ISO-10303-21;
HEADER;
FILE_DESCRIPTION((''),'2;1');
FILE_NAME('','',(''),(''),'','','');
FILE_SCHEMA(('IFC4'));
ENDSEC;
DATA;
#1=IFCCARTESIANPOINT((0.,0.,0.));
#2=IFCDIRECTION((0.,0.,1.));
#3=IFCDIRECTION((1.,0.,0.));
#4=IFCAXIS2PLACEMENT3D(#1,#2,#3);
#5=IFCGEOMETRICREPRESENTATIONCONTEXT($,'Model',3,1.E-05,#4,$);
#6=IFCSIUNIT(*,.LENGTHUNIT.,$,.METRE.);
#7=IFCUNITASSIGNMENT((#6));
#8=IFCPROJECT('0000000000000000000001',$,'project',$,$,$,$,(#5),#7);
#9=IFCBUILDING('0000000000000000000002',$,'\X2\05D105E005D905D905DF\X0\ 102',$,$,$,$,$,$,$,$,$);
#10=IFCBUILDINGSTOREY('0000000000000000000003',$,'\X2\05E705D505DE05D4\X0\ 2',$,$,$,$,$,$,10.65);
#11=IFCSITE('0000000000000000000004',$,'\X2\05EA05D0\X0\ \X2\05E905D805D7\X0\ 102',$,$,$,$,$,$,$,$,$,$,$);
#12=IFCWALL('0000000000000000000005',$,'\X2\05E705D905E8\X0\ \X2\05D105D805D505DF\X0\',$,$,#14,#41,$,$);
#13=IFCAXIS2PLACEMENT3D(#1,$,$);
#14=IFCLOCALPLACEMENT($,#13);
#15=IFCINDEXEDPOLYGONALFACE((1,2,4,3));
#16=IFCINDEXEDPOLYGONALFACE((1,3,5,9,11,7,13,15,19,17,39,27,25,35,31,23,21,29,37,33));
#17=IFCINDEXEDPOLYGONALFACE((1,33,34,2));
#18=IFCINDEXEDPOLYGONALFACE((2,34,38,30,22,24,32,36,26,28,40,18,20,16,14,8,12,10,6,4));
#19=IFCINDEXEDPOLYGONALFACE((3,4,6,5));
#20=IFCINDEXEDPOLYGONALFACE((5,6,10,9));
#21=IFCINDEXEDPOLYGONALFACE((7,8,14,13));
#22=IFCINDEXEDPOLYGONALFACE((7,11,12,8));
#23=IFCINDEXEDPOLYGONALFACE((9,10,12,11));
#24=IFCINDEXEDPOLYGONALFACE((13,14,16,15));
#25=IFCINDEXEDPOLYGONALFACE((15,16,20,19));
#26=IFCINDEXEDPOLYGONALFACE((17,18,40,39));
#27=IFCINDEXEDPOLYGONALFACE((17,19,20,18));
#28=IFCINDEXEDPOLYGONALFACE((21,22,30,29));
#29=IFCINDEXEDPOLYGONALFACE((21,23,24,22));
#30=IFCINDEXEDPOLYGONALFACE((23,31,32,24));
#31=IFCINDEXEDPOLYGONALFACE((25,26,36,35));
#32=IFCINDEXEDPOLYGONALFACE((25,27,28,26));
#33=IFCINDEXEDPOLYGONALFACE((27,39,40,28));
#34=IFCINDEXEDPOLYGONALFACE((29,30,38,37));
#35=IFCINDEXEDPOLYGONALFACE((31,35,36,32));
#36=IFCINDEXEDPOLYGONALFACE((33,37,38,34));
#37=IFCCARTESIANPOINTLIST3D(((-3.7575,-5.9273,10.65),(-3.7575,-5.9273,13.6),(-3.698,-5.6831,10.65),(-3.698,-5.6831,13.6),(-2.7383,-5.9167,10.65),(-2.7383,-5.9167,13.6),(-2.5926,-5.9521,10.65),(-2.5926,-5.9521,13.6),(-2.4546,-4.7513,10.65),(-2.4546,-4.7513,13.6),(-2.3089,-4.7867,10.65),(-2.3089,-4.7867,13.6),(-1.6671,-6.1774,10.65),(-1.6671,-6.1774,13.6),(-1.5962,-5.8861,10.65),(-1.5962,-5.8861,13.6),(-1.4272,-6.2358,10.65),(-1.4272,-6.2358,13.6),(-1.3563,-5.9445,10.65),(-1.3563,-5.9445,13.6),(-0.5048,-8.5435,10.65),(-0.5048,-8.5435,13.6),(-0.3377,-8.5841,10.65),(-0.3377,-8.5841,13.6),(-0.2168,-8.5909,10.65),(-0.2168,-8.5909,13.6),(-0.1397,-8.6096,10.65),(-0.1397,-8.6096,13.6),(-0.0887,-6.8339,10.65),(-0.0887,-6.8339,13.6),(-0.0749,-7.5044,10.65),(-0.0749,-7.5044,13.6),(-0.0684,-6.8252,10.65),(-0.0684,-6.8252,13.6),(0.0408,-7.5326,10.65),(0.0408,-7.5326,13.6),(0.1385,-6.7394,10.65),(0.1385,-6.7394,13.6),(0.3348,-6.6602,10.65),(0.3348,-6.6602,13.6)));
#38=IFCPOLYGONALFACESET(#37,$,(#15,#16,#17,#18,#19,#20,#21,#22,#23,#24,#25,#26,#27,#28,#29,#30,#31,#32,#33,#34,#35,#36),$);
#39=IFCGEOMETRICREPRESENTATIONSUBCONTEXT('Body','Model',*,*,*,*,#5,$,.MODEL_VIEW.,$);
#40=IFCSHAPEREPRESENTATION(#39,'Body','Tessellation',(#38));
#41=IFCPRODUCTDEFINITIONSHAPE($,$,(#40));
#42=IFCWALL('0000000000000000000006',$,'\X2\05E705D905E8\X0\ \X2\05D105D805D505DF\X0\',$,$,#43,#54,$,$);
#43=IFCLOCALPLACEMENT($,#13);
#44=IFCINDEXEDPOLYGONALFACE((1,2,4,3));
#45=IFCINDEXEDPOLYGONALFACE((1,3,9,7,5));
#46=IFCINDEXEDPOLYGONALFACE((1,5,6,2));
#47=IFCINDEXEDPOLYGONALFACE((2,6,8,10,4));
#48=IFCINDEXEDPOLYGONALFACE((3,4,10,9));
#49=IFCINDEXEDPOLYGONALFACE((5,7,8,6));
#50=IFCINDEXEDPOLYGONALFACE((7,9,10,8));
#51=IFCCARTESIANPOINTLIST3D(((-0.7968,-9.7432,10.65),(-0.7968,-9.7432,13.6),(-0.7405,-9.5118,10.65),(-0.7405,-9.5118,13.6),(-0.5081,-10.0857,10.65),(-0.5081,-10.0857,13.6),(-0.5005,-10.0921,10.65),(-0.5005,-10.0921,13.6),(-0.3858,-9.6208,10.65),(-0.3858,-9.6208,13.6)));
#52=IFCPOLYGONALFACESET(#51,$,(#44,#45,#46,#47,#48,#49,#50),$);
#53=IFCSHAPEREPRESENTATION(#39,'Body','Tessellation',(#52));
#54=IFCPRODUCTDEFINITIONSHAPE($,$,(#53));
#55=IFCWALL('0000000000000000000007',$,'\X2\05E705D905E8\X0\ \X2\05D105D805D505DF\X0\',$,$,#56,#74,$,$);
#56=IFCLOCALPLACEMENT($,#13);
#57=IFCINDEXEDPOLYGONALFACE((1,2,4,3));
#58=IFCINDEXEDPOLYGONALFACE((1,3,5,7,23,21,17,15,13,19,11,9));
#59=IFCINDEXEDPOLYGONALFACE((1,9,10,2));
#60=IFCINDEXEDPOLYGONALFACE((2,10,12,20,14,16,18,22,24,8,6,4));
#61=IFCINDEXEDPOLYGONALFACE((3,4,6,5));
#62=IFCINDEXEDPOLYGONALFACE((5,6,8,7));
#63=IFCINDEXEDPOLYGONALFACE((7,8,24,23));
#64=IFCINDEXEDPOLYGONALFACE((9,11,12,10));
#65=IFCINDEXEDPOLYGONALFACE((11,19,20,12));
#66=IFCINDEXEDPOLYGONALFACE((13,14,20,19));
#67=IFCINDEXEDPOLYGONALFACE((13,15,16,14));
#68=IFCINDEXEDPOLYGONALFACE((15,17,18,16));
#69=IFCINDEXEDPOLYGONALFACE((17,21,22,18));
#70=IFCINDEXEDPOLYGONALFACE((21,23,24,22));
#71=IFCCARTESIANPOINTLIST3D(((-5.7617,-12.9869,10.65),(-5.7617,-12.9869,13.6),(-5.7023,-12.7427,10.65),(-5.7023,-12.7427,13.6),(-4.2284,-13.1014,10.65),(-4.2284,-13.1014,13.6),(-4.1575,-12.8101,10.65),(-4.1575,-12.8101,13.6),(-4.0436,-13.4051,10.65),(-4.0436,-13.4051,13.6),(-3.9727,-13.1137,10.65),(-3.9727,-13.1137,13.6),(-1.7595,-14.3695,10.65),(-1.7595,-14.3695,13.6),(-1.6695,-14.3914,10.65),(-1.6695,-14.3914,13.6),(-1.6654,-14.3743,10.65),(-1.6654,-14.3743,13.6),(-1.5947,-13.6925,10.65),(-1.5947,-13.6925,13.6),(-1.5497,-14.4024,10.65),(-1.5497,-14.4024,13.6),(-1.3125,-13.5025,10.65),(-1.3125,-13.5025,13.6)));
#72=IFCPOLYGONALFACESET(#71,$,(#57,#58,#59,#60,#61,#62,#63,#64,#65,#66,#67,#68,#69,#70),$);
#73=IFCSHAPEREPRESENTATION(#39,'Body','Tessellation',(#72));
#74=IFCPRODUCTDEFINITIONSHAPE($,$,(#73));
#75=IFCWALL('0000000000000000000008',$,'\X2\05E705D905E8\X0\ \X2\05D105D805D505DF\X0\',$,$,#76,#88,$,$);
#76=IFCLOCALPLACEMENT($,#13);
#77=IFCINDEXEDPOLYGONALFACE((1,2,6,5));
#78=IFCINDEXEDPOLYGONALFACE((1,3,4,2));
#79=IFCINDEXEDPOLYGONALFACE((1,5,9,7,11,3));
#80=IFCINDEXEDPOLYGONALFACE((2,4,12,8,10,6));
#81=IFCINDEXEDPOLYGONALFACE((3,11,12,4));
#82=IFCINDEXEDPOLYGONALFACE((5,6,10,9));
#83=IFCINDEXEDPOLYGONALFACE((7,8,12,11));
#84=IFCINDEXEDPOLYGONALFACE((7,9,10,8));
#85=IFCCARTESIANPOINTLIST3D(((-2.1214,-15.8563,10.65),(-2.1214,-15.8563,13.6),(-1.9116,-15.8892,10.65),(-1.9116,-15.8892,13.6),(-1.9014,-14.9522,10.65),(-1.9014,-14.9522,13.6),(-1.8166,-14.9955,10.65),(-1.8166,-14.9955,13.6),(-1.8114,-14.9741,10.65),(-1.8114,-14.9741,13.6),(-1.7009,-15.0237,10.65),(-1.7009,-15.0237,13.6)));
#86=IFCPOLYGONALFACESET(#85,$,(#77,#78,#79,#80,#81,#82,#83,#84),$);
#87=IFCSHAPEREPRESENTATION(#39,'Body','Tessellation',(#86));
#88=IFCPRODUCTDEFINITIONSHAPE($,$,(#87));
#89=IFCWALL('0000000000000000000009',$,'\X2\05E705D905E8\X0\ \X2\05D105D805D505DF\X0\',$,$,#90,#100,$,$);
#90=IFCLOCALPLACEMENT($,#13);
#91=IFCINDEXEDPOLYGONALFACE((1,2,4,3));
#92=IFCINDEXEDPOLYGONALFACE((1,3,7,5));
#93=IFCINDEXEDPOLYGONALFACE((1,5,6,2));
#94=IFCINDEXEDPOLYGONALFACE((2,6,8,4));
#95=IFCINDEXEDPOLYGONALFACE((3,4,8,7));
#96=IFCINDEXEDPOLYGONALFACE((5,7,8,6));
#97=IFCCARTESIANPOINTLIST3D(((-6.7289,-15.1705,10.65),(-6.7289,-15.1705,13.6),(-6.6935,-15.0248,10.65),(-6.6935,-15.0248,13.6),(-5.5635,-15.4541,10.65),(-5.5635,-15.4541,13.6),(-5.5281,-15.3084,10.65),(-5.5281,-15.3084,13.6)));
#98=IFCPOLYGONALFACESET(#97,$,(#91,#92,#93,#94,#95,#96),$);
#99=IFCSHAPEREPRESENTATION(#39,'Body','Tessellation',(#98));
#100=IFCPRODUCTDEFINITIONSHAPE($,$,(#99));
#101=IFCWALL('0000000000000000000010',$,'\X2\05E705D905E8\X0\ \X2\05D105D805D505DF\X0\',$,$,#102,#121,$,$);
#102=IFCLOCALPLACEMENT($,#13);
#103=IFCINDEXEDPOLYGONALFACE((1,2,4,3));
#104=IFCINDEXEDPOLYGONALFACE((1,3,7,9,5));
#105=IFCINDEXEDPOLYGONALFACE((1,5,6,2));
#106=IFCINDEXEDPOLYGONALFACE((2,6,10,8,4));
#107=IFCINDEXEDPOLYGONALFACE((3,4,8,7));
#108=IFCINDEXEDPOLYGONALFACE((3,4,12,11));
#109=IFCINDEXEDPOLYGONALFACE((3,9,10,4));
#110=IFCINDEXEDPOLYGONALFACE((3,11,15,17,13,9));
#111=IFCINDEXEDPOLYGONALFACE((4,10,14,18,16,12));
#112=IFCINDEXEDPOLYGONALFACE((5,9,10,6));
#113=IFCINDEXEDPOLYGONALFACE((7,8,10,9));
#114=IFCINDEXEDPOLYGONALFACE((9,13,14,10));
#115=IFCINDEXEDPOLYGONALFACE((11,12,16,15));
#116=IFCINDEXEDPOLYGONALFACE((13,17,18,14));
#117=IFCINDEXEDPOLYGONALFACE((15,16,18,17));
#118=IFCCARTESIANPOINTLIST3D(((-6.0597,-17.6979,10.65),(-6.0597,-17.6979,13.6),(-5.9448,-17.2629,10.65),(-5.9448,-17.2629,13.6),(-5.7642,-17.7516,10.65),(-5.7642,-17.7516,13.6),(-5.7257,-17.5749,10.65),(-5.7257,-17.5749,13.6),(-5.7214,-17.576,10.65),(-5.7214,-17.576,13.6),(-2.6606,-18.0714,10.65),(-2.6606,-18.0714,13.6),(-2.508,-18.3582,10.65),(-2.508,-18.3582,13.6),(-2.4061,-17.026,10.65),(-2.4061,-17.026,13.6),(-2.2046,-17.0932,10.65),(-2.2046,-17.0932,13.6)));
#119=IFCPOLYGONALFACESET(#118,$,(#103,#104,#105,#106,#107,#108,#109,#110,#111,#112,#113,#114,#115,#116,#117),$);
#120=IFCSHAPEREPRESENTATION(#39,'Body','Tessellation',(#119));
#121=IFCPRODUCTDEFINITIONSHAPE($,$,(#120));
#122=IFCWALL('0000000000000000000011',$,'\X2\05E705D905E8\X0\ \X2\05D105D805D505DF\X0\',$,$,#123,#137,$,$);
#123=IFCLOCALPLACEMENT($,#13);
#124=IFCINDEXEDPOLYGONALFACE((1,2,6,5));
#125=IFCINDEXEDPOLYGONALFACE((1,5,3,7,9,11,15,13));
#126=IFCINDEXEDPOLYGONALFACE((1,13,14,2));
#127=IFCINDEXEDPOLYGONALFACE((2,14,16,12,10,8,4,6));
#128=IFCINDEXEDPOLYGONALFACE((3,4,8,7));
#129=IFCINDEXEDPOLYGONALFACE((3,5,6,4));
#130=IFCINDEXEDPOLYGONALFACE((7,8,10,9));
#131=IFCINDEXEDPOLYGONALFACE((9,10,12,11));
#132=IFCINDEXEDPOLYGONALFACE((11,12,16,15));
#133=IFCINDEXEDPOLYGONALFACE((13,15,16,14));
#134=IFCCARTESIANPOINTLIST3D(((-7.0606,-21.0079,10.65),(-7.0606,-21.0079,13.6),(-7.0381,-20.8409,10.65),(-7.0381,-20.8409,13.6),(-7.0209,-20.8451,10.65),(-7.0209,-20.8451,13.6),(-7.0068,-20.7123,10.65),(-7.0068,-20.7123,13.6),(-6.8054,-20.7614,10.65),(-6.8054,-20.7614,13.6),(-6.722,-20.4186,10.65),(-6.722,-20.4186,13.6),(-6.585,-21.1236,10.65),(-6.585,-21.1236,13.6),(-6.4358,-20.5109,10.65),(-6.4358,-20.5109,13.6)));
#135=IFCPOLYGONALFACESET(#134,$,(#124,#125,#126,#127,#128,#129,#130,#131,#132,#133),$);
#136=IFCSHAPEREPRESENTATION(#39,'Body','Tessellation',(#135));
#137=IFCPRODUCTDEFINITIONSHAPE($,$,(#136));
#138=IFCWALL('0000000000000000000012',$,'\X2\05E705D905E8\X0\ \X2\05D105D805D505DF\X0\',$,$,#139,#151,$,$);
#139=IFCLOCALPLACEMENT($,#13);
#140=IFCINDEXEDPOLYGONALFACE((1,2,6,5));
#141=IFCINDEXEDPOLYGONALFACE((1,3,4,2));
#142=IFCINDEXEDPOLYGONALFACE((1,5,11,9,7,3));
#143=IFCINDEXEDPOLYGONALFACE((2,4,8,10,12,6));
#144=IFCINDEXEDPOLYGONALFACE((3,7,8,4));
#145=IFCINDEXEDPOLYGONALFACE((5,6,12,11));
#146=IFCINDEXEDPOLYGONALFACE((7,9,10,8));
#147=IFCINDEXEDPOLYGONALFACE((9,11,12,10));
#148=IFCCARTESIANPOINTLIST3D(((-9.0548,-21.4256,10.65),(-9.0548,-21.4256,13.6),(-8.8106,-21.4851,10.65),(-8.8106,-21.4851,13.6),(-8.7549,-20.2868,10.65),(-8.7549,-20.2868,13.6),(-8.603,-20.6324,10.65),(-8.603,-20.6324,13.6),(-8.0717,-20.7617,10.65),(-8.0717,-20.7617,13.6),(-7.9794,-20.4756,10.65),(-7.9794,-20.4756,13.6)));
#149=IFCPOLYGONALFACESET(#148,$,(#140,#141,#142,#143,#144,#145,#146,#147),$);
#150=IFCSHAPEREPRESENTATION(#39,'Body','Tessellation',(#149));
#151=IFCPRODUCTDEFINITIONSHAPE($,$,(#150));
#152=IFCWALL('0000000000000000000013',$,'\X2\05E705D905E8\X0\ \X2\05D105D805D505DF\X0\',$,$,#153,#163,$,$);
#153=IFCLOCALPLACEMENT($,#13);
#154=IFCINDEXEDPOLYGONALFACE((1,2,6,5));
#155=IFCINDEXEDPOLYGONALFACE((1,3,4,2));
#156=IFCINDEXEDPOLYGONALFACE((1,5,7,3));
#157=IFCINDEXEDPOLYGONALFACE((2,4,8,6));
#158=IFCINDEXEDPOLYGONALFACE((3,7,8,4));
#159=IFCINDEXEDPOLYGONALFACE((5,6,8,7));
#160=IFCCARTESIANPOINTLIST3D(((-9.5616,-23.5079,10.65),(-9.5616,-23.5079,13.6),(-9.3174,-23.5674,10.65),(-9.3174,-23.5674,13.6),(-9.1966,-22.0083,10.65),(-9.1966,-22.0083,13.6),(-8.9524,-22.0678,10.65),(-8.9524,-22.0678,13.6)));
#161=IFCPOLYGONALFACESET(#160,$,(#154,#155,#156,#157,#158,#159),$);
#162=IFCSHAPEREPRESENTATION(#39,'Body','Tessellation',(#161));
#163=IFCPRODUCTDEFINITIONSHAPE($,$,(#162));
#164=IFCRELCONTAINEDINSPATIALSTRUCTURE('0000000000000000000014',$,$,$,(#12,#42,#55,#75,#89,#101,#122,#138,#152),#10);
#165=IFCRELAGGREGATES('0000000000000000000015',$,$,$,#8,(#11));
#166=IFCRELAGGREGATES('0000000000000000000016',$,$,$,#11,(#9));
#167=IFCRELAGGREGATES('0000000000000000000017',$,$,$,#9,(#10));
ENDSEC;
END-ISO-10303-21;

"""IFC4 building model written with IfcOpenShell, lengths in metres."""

from ifc_helpers import new_model, si_unit, frame, origin_with_axes, context, subcontext, project, spatial, polyline, outline, extrude, element, save


model = new_model("IFC4")

# Units and contexts
model_context = context("Model", 3, precision=1e-05, world=origin_with_axes())
body_context = subcontext(model_context, "Body", "Model", "MODEL_VIEW")
ifc_project = project(units=[si_unit("LENGTHUNIT", "METRE")], contexts=[model_context])

# Site, building, storey
site = spatial("IfcSite", under=ifc_project, Name="תא שטח 102")
building = spatial("IfcBuilding", under=site, Name="בניין 102")
storey = spatial("IfcBuildingStorey", under=building, Name="קומה 2", Elevation=10.65)

# Walls
element("IfcWall", 1, inside=storey, Name="קיר בטון", context=body_context, shape_type="SweptSolid", body=[
    extrude(outline(polyline([(-2.4546, -4.7513), (-2.7383, -5.9167), (-3.698, -5.6831), (-3.7575, -5.9273), (-0.0684, -6.8252), (0.1385, -6.7394), (-0.0887, -6.8339), (-0.5048, -8.5435), (-0.3377, -8.5841), (-0.0749, -7.5044), (0.0408, -7.5326), (-0.2168, -8.5909), (-0.1397, -8.6096), (0.3348, -6.6602), (-1.4272, -6.2358), (-1.3563, -5.9445), (-1.5962, -5.8861), (-1.6671, -6.1774), (-2.5926, -5.9521), (-2.3089, -4.7867), (-2.4546, -4.7513)])), frame((0.0, 0.0, 10.65)), (0.0, 0.0, 1.0), 2.95),
])
element("IfcWall", 2, inside=storey, Name="קיר בטון", context=body_context, shape_type="SweptSolid", body=[
    extrude(outline(polyline([(-0.3858, -9.6208), (-0.7405, -9.5118), (-0.7968, -9.7432), (-0.5081, -10.0857), (-0.5005, -10.0921), (-0.3858, -9.6208)])), frame((0.0, 0.0, 10.65)), (0.0, 0.0, 1.0), 2.95),
])
element("IfcWall", 3, inside=storey, Name="קיר בטון", context=body_context, shape_type="SweptSolid", body=[
    extrude(outline(polyline([(-5.7617, -12.9869), (-4.0436, -13.4051), (-3.9727, -13.1137), (-1.5947, -13.6925), (-1.7595, -14.3695), (-1.6695, -14.3914), (-1.6654, -14.3743), (-1.5497, -14.4024), (-1.3125, -13.5025), (-4.1575, -12.8101), (-4.2284, -13.1014), (-5.7023, -12.7427), (-5.7617, -12.9869)])), frame((0.0, 0.0, 10.65)), (0.0, 0.0, 1.0), 2.95),
])
element("IfcWall", 4, inside=storey, Name="קיר בטון", context=body_context, shape_type="SweptSolid", body=[
    extrude(outline(polyline([(-2.1214, -15.8563), (-1.9116, -15.8892), (-1.7009, -15.0237), (-1.8166, -14.9955), (-1.8114, -14.9741), (-1.9014, -14.9522), (-2.1214, -15.8563)])), frame((0.0, 0.0, 10.65)), (0.0, 0.0, 1.0), 2.95),
])
element("IfcWall", 5, inside=storey, Name="קיר בטון", context=body_context, shape_type="SweptSolid", body=[
    extrude(outline(polyline([(-6.7289, -15.1705), (-5.5635, -15.4541), (-5.5281, -15.3084), (-6.6935, -15.0248), (-6.7289, -15.1705)])), frame((0.0, 0.0, 10.65)), (0.0, 0.0, 1.0), 2.95),
])
element("IfcWall", 6, inside=storey, Name="קיר בטון", context=body_context, shape_type="SweptSolid", body=[
    extrude(outline(polyline([(-5.9448, -17.2629), (-6.0597, -17.6979), (-5.7642, -17.7516), (-5.7214, -17.576), (-2.508, -18.3582), (-2.2046, -17.0932), (-2.4061, -17.026), (-2.6606, -18.0714), (-5.9448, -17.2629)]), holes=[polyline([(-5.7257, -17.5749), (-5.7214, -17.576), (-5.9448, -17.2629), (-5.7257, -17.5749)])]), frame((0.0, 0.0, 10.65)), (0.0, 0.0, 1.0), 2.95),
])
element("IfcWall", 7, inside=storey, Name="קיר בטון", context=body_context, shape_type="SweptSolid", body=[
    extrude(outline(polyline([(-7.0209, -20.8451), (-7.0606, -21.0079), (-6.585, -21.1236), (-6.4358, -20.5109), (-6.722, -20.4186), (-6.8054, -20.7614), (-7.0068, -20.7123), (-7.0381, -20.8409), (-7.0209, -20.8451)])), frame((0.0, 0.0, 10.65)), (0.0, 0.0, 1.0), 2.95),
])
element("IfcWall", 8, inside=storey, Name="קיר בטון", context=body_context, shape_type="SweptSolid", body=[
    extrude(outline(polyline([(-9.0548, -21.4256), (-8.8106, -21.4851), (-8.603, -20.6324), (-8.0717, -20.7617), (-7.9794, -20.4756), (-8.7549, -20.2868), (-9.0548, -21.4256)])), frame((0.0, 0.0, 10.65)), (0.0, 0.0, 1.0), 2.95),
])
element("IfcWall", 9, inside=storey, Name="קיר בטון", context=body_context, shape_type="SweptSolid", body=[
    extrude(outline(polyline([(-9.3174, -23.5674), (-8.9524, -22.0678), (-9.1966, -22.0083), (-9.5616, -23.5079), (-9.3174, -23.5674)])), frame((0.0, 0.0, 10.65)), (0.0, 0.0, 1.0), 2.95),
])

save(model, "model.ifc")
